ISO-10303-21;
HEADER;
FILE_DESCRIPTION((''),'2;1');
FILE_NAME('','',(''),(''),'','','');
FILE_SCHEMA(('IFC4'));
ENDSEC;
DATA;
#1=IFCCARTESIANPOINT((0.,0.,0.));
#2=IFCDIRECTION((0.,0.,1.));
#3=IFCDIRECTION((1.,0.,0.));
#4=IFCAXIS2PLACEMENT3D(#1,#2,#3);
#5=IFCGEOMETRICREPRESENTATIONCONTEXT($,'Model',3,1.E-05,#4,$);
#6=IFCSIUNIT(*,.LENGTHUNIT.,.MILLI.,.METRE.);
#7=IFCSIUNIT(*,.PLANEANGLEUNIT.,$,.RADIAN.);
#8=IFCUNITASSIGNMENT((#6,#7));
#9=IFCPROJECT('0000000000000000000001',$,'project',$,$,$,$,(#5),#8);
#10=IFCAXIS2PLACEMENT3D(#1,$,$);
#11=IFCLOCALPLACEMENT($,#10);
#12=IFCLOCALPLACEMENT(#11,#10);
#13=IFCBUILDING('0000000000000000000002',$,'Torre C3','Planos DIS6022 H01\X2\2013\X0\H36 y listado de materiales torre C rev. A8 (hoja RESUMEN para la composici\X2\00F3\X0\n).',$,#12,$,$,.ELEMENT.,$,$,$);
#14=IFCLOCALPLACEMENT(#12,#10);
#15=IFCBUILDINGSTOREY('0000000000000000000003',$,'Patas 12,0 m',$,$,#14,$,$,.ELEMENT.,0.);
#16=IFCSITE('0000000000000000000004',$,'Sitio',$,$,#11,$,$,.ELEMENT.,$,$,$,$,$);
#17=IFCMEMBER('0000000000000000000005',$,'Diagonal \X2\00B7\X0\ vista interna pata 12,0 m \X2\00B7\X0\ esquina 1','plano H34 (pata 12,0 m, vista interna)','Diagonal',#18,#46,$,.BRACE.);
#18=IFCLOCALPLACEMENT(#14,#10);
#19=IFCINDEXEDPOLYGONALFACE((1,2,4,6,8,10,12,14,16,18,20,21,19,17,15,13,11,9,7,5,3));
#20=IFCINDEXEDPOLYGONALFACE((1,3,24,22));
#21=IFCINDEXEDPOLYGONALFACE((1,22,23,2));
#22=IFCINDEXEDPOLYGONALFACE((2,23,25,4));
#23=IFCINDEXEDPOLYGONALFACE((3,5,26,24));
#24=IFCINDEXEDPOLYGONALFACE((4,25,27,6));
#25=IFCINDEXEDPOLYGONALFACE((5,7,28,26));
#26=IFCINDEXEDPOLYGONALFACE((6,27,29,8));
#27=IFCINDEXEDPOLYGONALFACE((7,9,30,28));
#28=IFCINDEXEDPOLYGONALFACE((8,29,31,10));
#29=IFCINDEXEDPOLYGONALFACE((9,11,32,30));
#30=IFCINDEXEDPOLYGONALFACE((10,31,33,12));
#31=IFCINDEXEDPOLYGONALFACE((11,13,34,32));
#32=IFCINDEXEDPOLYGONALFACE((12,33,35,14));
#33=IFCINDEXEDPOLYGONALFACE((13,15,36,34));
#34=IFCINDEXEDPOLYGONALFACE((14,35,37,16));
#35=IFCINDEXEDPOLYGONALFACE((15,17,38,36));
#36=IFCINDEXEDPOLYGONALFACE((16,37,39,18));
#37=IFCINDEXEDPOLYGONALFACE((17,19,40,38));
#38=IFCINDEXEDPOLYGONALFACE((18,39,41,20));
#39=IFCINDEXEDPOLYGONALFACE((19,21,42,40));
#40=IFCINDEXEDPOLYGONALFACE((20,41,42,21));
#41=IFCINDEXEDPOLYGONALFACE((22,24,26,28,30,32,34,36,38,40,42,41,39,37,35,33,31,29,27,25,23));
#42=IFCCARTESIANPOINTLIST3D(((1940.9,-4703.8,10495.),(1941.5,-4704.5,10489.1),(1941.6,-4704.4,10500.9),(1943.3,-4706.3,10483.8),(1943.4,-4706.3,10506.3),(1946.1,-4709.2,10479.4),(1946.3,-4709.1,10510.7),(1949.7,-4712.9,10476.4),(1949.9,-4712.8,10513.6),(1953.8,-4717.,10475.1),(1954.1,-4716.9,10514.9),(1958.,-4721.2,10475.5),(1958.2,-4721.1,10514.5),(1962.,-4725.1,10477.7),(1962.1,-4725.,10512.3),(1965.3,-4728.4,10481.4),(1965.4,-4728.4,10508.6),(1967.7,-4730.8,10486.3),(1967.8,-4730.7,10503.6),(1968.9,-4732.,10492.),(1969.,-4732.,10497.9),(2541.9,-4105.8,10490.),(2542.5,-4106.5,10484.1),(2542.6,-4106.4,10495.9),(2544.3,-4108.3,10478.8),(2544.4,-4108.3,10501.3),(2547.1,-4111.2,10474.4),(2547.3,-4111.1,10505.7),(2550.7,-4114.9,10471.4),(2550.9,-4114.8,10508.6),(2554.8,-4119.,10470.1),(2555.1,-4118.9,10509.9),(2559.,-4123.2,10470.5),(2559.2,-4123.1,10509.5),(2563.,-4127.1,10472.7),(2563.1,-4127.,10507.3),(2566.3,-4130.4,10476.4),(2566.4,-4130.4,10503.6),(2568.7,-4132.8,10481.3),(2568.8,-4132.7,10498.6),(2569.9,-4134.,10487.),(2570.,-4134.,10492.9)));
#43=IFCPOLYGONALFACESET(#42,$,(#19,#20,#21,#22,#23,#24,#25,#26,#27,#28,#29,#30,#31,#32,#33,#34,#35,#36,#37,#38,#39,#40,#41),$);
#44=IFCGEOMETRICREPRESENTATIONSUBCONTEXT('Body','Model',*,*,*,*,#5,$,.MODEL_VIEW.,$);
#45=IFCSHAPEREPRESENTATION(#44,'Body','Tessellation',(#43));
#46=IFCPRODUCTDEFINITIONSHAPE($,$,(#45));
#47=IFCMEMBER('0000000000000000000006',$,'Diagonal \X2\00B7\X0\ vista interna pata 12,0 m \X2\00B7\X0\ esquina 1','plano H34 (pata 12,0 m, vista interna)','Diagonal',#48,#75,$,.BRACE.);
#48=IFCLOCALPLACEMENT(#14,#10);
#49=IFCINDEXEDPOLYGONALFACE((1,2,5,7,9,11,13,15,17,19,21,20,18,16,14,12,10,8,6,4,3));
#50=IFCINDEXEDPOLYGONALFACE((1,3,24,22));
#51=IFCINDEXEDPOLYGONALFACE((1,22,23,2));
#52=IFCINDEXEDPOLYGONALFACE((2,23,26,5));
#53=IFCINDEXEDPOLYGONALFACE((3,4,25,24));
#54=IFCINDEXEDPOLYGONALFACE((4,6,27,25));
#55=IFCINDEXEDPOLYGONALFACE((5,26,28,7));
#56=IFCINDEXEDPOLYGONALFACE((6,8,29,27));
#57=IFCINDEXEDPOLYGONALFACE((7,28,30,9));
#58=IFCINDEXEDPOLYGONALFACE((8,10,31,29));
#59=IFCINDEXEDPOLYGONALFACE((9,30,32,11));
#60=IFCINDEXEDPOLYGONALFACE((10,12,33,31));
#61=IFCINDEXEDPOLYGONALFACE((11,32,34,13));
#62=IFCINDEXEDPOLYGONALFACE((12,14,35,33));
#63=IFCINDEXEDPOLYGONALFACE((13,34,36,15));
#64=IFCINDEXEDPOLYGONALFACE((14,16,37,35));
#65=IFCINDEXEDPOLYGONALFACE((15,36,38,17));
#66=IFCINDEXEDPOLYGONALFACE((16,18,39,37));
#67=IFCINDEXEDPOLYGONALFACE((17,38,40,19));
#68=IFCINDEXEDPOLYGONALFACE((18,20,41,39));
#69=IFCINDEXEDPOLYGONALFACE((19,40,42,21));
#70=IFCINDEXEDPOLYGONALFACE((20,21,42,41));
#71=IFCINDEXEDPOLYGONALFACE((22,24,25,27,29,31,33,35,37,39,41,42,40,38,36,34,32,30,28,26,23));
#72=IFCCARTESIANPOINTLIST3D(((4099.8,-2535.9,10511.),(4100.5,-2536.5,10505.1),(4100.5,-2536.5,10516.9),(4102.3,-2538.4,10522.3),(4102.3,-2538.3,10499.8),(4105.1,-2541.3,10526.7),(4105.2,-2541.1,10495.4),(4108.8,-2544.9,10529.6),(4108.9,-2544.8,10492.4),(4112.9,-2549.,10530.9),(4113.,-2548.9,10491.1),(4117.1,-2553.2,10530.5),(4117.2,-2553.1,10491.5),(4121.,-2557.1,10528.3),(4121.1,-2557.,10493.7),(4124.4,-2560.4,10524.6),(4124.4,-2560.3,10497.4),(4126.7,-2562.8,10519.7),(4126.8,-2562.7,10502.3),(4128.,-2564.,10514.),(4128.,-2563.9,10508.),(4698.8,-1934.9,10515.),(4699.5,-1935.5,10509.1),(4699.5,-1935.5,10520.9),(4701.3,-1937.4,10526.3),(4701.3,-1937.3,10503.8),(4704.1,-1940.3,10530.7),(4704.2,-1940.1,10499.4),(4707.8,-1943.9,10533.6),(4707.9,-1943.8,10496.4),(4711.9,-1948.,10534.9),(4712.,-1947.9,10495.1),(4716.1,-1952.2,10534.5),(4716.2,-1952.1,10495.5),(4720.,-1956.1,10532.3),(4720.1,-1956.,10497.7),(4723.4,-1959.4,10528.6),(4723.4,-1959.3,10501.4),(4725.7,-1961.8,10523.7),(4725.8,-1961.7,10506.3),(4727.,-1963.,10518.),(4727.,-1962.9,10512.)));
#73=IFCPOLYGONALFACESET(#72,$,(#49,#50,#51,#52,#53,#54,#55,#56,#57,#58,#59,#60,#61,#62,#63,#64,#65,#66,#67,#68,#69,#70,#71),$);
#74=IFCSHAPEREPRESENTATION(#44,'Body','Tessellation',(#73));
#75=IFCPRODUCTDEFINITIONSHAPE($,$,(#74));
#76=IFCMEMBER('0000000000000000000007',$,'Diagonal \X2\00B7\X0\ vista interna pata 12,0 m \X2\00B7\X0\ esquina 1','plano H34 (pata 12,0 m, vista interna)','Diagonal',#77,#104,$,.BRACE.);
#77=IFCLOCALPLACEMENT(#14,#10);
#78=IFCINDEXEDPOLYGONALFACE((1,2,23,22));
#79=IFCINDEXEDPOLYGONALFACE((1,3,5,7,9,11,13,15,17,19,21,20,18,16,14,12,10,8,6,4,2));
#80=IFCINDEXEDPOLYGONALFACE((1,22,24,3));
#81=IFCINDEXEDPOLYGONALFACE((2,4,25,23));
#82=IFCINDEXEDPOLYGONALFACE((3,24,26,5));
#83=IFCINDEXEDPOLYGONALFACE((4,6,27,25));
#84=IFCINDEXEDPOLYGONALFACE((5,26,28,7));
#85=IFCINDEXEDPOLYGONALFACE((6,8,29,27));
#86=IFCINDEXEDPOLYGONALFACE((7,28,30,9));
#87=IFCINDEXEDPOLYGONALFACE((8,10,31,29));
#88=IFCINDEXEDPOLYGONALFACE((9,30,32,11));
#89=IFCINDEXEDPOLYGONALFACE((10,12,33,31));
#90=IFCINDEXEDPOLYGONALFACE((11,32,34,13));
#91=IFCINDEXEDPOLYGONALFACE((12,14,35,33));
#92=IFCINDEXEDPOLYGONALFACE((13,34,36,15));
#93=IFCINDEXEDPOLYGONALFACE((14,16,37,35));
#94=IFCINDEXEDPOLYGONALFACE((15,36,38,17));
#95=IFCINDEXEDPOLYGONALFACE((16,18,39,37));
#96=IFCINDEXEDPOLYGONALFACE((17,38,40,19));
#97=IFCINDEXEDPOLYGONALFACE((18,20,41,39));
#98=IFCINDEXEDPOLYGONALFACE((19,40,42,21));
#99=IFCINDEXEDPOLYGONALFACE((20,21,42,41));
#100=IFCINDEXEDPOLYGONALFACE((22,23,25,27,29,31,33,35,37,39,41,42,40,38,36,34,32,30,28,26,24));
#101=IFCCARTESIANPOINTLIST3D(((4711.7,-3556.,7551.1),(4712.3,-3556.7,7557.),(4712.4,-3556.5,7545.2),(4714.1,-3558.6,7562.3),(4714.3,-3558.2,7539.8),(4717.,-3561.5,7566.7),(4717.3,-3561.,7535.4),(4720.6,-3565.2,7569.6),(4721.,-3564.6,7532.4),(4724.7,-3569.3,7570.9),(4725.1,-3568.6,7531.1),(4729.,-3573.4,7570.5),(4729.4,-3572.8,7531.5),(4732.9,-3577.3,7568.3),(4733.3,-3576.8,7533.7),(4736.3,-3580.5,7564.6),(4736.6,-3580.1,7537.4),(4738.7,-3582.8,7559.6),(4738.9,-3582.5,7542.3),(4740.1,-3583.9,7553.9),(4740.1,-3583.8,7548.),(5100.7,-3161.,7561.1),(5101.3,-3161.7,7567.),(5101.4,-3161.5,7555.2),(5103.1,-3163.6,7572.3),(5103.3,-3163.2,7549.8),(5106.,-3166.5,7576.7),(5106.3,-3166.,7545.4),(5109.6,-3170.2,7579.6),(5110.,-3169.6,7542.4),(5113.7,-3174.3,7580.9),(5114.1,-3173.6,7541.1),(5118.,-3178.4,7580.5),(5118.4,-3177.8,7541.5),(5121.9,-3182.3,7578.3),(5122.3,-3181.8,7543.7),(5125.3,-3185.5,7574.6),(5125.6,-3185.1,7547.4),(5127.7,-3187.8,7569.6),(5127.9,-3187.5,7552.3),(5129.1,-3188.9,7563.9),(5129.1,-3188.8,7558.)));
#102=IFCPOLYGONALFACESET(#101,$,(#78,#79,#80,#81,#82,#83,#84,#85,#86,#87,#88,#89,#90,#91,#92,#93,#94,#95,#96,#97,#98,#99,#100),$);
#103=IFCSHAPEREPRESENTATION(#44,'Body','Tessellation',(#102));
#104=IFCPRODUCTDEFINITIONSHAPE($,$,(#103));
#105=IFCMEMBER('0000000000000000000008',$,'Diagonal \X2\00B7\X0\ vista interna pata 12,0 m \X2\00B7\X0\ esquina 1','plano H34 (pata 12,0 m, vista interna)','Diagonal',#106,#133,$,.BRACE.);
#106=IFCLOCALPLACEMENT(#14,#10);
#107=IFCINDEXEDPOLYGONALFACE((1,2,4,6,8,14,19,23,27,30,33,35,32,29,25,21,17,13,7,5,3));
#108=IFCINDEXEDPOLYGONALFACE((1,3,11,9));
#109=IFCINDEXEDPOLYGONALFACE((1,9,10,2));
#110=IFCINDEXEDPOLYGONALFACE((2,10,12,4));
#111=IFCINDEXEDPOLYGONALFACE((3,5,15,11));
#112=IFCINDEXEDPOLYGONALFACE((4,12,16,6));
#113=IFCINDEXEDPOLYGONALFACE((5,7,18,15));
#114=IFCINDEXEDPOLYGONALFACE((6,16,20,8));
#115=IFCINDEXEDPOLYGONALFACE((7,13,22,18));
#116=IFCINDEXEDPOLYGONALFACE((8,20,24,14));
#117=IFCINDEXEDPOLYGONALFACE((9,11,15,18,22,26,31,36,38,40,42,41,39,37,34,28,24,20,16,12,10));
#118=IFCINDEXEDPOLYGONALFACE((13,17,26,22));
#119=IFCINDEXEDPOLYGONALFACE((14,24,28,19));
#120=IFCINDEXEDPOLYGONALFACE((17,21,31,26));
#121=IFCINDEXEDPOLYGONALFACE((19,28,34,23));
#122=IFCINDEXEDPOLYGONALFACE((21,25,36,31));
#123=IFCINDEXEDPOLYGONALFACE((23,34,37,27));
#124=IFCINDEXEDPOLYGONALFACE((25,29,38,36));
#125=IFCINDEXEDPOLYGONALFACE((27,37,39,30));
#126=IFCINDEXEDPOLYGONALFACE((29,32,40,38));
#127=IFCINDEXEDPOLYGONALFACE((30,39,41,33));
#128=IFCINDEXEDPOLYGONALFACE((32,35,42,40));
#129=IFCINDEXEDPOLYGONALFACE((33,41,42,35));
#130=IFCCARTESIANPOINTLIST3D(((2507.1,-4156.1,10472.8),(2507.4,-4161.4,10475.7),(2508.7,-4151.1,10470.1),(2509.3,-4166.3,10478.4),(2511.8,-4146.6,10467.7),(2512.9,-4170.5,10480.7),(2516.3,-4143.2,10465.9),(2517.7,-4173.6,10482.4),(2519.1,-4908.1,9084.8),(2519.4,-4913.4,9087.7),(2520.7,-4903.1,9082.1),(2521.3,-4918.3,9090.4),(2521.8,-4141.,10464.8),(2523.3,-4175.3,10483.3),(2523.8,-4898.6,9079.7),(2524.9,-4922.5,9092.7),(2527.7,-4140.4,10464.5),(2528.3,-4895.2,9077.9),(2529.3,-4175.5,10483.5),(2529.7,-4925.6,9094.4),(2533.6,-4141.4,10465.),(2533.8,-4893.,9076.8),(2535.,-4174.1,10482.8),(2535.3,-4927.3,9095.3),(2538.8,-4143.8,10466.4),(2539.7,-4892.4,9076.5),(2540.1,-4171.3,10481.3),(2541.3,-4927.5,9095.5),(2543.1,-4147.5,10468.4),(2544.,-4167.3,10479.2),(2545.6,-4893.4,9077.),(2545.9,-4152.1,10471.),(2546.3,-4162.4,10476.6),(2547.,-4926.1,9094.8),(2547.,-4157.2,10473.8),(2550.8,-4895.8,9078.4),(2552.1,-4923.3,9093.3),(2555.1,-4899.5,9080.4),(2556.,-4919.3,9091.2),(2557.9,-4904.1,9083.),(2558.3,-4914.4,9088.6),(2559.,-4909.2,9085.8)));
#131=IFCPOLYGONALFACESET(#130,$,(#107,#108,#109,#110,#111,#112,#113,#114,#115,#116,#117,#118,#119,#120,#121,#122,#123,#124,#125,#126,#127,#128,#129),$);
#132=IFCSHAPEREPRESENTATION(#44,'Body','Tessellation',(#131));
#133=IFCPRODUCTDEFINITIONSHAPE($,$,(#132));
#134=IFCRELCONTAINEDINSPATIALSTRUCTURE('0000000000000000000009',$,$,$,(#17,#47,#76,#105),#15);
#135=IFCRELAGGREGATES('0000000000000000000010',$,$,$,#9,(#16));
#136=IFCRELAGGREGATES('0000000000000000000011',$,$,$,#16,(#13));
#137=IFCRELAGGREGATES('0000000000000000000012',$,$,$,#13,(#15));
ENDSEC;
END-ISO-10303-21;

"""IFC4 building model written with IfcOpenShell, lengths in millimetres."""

from ifc_helpers import new_model, si_unit, frame, origin, origin_with_axes, place, context, subcontext, project, spatial, circle, extrude, element, save


model = new_model("IFC4")

# Units and contexts
model_context = context("Model", 3, precision=1e-05, world=origin_with_axes())
body_context = subcontext(model_context, "Body", "Model", "MODEL_VIEW")
ifc_project = project(units=[si_unit("LENGTHUNIT", "METRE", prefix="MILLI"), si_unit("PLANEANGLEUNIT", "RADIAN")], contexts=[model_context])

# Site, building, storey
site_placement = place(None, origin())
site = spatial("IfcSite", under=ifc_project, at=site_placement, Name="Sitio", CompositionType="ELEMENT")
building_placement = place(site_placement, origin())
building = spatial("IfcBuilding", under=site, at=building_placement, Name="Torre C3", Description="Planos DIS6022 H01–H36 y listado de materiales torre C rev. A8 (hoja RESUMEN para la composición).", CompositionType="ELEMENT")
storey_placement = place(building_placement, origin())
storey = spatial("IfcBuildingStorey", under=building, at=storey_placement, Name="Patas 12,0 m", CompositionType="ELEMENT", Elevation=0.0)

# Members
member_1_placement = place(storey_placement, frame((1955.0, -4718.0, 10495.0), z_axis=(0.708861, 0.705323, -0.005897), x_axis=(-0.705326, 0.70888, 0.001895)))
element("IfcMember", 1, at=member_1_placement, inside=storey, Name="Diagonal · vista interna pata 12,0 m · esquina 1", Description="plano H34 (pata 12,0 m, vista interna)", ObjectType="Diagonal", PredefinedType="BRACE", context=body_context, shape_type="SweptSolid", body=[
    extrude(circle(Radius=20.0), None, (0.0, 0.0, 1.0), 847.8),
])
member_2_placement = place(storey_placement, frame((4114.0, -2550.0, 10511.0), z_axis=(0.705919, 0.708276, 0.004714), x_axis=(-0.708289, 0.705921, 0.001522)))
element("IfcMember", 2, at=member_2_placement, inside=storey, Name="Diagonal · vista interna pata 12,0 m · esquina 1", Description="plano H34 (pata 12,0 m, vista interna)", ObjectType="Diagonal", PredefinedType="BRACE", context=body_context, shape_type="SweptSolid", body=[
    extrude(circle(Radius=20.0), None, (0.0, 0.0, 1.0), 848.5),
])
member_3_placement = place(storey_placement, frame((4726.0, -3570.0, 7551.0), z_axis=(0.701561, 0.712382, 0.018035), x_axis=(-0.712535, 0.70163, 0.003223)))
element("IfcMember", 3, at=member_3_placement, inside=storey, Name="Diagonal · vista interna pata 12,0 m · esquina 1", Description="plano H34 (pata 12,0 m, vista interna)", ObjectType="Diagonal", PredefinedType="BRACE", context=body_context, shape_type="SweptSolid", body=[
    extrude(circle(Radius=20.0), None, (0.0, 0.0, 1.0), 554.5),
])
member_4_placement = place(storey_placement, frame((2539.0, -4910.0, 9086.0), z_axis=(-0.007601, 0.476351, 0.879222), x_axis=(-0.533783, 0.74157, -0.406387)))
element("IfcMember", 4, at=member_4_placement, inside=storey, Name="Diagonal · vista interna pata 12,0 m · esquina 1", Description="plano H34 (pata 12,0 m, vista interna)", ObjectType="Diagonal", PredefinedType="BRACE", context=body_context, shape_type="SweptSolid", body=[
    extrude(circle(Radius=20.0), None, (0.0, 0.0, 1.0), 1578.7),
])

save(model, "model.ifc")
